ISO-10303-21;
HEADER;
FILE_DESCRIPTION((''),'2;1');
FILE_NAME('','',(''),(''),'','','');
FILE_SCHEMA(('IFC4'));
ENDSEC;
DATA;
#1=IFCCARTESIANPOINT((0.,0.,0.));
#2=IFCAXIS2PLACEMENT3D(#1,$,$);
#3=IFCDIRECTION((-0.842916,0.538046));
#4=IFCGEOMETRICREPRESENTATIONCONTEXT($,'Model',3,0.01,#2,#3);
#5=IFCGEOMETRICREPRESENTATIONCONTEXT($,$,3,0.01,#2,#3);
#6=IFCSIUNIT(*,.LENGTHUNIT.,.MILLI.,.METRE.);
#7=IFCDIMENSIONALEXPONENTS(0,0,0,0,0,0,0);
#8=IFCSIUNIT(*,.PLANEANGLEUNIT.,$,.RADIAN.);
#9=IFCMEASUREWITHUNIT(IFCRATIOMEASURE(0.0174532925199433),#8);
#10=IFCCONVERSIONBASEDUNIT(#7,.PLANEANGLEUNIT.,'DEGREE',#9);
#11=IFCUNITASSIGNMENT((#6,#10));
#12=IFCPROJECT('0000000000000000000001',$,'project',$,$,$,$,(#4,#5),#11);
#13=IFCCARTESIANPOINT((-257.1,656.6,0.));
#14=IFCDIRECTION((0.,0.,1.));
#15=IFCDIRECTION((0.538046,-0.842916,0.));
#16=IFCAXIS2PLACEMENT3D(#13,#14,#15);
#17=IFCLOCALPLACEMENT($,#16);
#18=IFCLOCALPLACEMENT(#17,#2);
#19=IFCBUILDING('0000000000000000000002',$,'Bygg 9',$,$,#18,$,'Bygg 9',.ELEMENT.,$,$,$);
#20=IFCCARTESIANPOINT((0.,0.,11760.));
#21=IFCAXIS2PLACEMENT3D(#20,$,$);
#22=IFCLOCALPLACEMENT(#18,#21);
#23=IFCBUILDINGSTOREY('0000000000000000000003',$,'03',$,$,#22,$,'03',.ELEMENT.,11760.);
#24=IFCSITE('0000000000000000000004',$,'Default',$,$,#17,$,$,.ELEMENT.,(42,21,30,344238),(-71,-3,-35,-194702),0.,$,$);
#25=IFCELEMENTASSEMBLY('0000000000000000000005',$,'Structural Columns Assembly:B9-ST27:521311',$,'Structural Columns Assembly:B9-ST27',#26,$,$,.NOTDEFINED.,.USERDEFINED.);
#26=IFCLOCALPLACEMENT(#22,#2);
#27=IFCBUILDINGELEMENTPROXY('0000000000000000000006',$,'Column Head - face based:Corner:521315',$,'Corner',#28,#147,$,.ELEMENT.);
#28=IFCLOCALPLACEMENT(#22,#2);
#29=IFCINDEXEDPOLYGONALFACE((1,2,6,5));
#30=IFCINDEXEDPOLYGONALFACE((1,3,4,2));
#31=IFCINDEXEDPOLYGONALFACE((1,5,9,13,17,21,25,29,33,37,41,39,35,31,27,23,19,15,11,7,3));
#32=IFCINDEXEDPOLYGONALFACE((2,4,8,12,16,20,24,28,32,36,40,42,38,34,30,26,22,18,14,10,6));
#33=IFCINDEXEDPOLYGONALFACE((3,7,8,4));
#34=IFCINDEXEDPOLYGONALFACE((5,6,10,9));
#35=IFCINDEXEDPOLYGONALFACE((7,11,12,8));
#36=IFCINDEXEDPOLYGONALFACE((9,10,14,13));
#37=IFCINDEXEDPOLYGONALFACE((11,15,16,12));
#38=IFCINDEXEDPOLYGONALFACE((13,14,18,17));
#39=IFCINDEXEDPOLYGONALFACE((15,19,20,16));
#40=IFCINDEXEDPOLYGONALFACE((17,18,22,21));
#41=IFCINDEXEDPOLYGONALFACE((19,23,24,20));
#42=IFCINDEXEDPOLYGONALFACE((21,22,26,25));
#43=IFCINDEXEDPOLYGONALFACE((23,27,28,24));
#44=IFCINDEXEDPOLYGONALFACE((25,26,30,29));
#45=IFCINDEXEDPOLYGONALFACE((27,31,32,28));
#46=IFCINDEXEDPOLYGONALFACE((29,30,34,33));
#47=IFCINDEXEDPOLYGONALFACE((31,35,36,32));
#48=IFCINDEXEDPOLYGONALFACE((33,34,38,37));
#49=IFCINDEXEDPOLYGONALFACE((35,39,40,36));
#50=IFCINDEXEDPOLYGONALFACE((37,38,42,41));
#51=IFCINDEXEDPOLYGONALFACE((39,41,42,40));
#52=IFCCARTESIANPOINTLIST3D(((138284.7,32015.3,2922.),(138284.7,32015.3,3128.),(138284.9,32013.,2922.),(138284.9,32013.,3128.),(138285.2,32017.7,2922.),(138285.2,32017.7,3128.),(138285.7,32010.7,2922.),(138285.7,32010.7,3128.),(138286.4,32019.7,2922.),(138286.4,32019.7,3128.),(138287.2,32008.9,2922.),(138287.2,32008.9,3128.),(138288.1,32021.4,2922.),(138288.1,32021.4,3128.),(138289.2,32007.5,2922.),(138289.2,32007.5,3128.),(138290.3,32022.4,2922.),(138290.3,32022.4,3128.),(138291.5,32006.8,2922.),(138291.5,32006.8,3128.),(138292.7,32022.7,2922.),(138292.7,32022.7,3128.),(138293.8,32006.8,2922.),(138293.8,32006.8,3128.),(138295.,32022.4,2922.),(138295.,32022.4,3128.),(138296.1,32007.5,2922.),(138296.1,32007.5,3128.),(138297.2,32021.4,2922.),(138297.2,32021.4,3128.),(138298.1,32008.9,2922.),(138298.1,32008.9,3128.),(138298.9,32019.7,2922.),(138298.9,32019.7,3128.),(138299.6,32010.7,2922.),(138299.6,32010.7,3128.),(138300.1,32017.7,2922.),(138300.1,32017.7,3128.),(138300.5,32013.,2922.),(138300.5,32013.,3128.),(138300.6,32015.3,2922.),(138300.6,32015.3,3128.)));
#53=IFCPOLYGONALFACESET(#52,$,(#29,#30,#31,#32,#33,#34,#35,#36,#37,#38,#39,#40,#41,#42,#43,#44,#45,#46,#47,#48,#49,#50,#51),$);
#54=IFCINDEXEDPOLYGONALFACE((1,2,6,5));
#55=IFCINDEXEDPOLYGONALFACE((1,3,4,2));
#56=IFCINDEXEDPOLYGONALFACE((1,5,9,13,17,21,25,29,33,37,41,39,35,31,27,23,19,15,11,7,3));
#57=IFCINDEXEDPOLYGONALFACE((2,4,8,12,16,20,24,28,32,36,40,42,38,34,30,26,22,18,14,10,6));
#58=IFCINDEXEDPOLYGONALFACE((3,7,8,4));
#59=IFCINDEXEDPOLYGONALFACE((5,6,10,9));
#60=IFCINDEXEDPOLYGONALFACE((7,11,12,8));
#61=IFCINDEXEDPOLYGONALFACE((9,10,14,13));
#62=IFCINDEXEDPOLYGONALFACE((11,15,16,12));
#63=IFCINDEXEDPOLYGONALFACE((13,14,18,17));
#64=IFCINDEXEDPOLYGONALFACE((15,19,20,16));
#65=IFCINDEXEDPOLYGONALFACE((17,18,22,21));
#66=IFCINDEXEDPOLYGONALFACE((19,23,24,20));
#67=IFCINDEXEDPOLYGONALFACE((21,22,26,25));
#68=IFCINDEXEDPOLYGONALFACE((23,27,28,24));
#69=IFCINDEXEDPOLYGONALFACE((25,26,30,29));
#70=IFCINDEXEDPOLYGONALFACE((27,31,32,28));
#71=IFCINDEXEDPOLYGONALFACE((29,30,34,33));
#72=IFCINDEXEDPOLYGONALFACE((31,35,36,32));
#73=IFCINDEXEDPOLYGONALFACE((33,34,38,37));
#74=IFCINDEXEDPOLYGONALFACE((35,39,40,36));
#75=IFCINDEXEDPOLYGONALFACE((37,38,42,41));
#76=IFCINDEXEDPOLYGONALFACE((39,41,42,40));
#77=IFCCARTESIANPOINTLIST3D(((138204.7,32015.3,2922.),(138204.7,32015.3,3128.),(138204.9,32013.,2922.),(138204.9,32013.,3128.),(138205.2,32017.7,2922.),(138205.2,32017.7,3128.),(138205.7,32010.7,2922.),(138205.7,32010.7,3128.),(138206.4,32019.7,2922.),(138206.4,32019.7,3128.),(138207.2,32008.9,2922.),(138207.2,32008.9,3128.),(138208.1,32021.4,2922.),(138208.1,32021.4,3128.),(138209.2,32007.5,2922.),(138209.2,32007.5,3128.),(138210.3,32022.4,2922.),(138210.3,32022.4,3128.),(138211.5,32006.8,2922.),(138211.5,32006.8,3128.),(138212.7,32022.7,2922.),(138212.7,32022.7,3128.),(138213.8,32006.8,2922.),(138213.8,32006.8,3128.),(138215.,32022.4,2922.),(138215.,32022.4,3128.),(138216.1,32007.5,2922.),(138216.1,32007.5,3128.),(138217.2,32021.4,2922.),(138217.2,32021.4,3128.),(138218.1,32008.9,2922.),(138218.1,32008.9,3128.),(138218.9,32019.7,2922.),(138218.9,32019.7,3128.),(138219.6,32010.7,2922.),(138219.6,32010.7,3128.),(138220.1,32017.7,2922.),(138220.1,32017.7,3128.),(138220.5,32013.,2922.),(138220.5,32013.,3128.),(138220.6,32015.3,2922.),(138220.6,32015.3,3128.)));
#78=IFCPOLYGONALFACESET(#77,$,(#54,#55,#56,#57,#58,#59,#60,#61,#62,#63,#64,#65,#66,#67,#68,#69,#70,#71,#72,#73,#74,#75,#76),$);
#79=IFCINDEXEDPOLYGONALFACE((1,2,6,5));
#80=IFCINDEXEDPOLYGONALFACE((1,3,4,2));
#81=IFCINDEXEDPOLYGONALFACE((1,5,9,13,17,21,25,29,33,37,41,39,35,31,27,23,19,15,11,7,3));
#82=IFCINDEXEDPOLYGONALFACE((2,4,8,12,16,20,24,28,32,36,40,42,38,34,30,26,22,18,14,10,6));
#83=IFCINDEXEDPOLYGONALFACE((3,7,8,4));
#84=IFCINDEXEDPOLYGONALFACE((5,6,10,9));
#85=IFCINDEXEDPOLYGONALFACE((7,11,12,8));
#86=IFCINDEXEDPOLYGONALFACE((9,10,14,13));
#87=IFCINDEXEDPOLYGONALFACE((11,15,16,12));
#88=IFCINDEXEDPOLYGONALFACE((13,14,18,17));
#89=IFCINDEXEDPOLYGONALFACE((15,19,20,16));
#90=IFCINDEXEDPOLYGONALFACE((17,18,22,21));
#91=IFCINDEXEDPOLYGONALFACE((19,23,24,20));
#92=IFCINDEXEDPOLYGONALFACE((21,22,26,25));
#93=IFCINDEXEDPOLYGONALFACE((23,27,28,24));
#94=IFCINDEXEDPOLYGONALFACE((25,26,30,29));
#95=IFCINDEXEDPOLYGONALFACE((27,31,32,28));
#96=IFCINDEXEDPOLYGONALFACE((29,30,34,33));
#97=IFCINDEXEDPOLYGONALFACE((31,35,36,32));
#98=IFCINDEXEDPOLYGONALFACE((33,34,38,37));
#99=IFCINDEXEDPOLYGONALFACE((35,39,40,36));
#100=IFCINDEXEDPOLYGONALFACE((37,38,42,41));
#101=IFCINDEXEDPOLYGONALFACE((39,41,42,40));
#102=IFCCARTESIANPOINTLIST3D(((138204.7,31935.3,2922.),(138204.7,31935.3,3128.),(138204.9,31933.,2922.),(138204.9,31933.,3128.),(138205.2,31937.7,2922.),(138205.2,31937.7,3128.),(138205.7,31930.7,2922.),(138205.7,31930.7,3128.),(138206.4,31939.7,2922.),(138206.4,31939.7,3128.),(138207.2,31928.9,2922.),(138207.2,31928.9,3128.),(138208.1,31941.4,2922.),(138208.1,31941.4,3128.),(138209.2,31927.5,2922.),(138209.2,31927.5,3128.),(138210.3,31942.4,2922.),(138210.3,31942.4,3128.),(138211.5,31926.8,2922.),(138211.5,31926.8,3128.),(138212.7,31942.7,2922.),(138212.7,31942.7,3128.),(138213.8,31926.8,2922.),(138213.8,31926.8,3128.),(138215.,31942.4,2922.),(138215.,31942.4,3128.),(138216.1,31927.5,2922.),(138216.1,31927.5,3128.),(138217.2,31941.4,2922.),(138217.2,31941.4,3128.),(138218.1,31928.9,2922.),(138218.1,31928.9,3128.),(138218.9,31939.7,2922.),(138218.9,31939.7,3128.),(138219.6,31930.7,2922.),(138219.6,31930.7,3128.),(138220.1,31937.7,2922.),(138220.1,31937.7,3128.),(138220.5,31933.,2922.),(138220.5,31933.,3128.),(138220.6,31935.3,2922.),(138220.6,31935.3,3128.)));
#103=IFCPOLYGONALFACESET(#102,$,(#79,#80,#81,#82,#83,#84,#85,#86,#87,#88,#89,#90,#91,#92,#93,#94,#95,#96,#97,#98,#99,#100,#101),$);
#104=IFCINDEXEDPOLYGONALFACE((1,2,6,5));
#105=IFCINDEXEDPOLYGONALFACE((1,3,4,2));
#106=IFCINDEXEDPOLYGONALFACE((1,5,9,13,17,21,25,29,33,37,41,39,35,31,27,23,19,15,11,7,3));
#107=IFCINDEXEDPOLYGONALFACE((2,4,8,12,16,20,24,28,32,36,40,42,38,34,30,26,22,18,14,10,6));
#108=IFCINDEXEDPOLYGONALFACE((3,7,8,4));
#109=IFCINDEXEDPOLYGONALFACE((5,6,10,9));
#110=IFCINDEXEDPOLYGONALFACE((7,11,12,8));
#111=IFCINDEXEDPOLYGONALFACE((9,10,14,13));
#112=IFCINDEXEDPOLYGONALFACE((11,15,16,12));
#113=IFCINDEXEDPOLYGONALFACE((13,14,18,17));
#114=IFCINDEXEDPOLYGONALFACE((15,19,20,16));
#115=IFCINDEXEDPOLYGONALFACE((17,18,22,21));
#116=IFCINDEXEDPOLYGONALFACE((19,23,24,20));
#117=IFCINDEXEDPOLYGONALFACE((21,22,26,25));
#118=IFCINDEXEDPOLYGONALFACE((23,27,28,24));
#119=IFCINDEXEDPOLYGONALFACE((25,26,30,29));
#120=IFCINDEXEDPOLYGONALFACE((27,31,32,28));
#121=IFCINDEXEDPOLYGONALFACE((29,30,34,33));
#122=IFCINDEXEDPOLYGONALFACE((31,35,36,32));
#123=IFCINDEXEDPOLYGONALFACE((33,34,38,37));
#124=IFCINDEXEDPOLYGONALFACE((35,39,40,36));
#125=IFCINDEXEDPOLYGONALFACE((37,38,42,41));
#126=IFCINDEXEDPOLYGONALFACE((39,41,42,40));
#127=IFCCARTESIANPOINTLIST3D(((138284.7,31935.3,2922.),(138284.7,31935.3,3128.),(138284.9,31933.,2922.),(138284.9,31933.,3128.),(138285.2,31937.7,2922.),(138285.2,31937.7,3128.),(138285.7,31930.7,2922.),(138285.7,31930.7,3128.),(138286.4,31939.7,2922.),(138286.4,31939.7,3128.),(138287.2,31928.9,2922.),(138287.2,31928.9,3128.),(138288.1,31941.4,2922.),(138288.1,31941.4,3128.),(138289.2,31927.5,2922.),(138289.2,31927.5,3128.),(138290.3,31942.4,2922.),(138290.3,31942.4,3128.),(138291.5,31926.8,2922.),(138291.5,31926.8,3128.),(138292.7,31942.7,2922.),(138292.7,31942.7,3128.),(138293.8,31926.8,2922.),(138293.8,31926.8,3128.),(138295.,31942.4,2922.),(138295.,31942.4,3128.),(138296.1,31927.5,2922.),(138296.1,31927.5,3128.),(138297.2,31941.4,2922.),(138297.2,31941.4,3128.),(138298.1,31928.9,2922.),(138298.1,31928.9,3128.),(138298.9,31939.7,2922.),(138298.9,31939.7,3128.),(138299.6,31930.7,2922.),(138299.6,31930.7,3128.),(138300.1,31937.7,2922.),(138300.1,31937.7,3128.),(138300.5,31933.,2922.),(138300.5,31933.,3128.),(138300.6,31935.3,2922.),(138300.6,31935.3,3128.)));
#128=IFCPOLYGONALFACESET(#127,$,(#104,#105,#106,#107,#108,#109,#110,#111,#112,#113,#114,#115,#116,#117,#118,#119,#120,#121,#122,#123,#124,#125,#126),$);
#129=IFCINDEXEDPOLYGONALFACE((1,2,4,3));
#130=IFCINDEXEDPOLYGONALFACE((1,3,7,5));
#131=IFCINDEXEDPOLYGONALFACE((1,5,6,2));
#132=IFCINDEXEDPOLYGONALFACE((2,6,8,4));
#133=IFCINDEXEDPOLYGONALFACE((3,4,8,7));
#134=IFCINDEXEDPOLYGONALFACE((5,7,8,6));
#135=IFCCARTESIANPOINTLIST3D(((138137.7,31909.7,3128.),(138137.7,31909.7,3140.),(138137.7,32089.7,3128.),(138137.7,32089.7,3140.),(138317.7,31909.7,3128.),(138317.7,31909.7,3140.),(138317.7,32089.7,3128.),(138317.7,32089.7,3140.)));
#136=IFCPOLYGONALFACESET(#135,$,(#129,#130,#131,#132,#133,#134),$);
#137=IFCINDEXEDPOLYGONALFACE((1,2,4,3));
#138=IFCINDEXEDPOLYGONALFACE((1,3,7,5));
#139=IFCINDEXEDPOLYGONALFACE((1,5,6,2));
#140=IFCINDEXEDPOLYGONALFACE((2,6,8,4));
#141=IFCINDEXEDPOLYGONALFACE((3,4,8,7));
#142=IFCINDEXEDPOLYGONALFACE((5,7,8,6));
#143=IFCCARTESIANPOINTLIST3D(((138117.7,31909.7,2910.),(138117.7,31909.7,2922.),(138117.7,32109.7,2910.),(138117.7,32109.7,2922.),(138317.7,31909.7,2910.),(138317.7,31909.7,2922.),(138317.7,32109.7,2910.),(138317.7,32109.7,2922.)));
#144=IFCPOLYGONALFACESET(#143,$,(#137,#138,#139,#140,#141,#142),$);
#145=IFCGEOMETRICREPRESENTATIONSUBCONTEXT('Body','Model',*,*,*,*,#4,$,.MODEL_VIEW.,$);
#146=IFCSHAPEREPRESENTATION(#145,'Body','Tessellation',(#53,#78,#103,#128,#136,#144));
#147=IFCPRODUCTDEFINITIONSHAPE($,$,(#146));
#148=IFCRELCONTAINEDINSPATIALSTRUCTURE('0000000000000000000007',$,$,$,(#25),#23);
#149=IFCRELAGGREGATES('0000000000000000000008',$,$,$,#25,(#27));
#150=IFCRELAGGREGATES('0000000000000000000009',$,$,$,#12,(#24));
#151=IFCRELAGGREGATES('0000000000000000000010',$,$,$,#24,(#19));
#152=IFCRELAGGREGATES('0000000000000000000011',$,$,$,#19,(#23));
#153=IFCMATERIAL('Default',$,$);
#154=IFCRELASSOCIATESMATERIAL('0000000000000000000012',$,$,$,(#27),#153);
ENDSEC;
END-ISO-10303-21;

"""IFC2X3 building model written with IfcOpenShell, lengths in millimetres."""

from ifc_helpers import new_model, entity, si_unit, converted_unit, direction, frame, frame_2d, origin, origin_2d_with_axis, place, context, subcontext, project, spatial, rectangle, circle, extrude, source, transform, mapped, material, element, aggregate, save


model = new_model("IFC2X3")

# Units and contexts
model_context = context("Model", 3, precision=0.01, world=origin(), true_north=direction((-0.842916, 0.538046)))
context_of_model = context(None, 3, precision=0.01, world=origin(), true_north=direction((-0.842916, 0.538046)))
body_context = subcontext(model_context, "Body", "Model", "MODEL_VIEW")
ifc_project = project(units=[si_unit("LENGTHUNIT", "METRE", prefix="MILLI"), converted_unit("PLANEANGLEUNIT", "DEGREE", entity("IfcRatioMeasure", 0.0174532925199433), si_unit("PLANEANGLEUNIT", "RADIAN"), dimensions=[0, 0, 0, 0, 0, 0, 0])], contexts=[model_context, context_of_model])

# Site, building, storey
site_placement = place(None, frame((-257.1, 656.6, 0.0), z_axis=(0.0, 0.0, 1.0), x_axis=(0.538046, -0.842916, 0.0)))
site = spatial("IfcSite", under=ifc_project, at=site_placement, Name="Default", CompositionType="ELEMENT", RefLatitude=(42, 21, 30, 344238), RefLongitude=(-71, -3, -35, -194702), RefElevation=0.0)
building_placement = place(site_placement, origin())
building = spatial("IfcBuilding", under=site, at=building_placement, Name="Bygg 9", LongName="Bygg 9", CompositionType="ELEMENT")
storey_placement = place(building_placement, frame((0.0, 0.0, 11760.0)))
storey = spatial("IfcBuildingStorey", under=building, at=storey_placement, Name="03", LongName="03", CompositionType="ELEMENT", Elevation=11760.0)

# Shared definitions
ifc_material_1 = material(Name="Default")

# Element assembly, building element proxy
assembly_1_placement = place(storey_placement, origin())
assembly_1 = element("IfcElementAssembly", 1, at=assembly_1_placement, inside=storey, Name="Structural Columns Assembly:B9-ST27:521311", ObjectType="Structural Columns Assembly:B9-ST27", AssemblyPlace="NOTDEFINED", PredefinedType="USERDEFINED")
shared_shape_1 = source(origin(), body_context, "Body", "SweptSolid", [
    extrude(circle(Radius=8.0, at=frame_2d((0.0, 0.0), x_axis=(1.0, 0.0))), frame((-55.0, -135.0, 12.0)), (0.0, 0.0, 1.0), 206.0),
    extrude(circle(Radius=8.0, at=frame_2d((0.0, 0.0), x_axis=(1.0, 0.0))), frame((-55.0, -55.0, 12.0)), (0.0, 0.0, 1.0), 206.0),
    extrude(circle(Radius=8.0, at=frame_2d((0.0, 0.0), x_axis=(1.0, 0.0))), frame((-135.0, -55.0, 12.0)), (0.0, 0.0, 1.0), 206.0),
    extrude(circle(Radius=8.0, at=frame_2d((0.0, 0.0), x_axis=(1.0, 0.0))), frame((-135.0, -135.0, 12.0)), (0.0, 0.0, 1.0), 206.0),
    extrude(rectangle(XDim=180.0, YDim=180.0, at=origin_2d_with_axis()), frame((-70.0, -70.0, 218.0), z_axis=(0.0, 0.0, 1.0), x_axis=(-1.0, 0.0, 0.0)), (0.0, 0.0, 1.0), 12.0),
    extrude(rectangle(XDim=200.0, YDim=200.0, at=origin_2d_with_axis()), frame((-60.0, -60.0, 0.0), z_axis=(0.0, 0.0, 1.0), x_axis=(0.0, 1.0, 0.0)), (0.0, 0.0, 1.0), 12.0),
])
proxy_1_placement = place(assembly_1_placement, frame((138157.7, 32069.7, 2910.0), z_axis=(0.0, 0.0, 1.0), x_axis=(0.0, 1.0, 0.0)))
proxy_1 = element("IfcBuildingElementProxy", 2, at=proxy_1_placement, material=ifc_material_1, Name="Column Head - face based:Corner:521315", ObjectType="Corner", CompositionType="ELEMENT", context=body_context, shape_type="MappedRepresentation", body=[
    mapped(shared_shape_1, transform((0.0, 0.0, 0.0), scale=1.0)),
])
aggregate(assembly_1, [proxy_1])

save(model, "model.ifc")
